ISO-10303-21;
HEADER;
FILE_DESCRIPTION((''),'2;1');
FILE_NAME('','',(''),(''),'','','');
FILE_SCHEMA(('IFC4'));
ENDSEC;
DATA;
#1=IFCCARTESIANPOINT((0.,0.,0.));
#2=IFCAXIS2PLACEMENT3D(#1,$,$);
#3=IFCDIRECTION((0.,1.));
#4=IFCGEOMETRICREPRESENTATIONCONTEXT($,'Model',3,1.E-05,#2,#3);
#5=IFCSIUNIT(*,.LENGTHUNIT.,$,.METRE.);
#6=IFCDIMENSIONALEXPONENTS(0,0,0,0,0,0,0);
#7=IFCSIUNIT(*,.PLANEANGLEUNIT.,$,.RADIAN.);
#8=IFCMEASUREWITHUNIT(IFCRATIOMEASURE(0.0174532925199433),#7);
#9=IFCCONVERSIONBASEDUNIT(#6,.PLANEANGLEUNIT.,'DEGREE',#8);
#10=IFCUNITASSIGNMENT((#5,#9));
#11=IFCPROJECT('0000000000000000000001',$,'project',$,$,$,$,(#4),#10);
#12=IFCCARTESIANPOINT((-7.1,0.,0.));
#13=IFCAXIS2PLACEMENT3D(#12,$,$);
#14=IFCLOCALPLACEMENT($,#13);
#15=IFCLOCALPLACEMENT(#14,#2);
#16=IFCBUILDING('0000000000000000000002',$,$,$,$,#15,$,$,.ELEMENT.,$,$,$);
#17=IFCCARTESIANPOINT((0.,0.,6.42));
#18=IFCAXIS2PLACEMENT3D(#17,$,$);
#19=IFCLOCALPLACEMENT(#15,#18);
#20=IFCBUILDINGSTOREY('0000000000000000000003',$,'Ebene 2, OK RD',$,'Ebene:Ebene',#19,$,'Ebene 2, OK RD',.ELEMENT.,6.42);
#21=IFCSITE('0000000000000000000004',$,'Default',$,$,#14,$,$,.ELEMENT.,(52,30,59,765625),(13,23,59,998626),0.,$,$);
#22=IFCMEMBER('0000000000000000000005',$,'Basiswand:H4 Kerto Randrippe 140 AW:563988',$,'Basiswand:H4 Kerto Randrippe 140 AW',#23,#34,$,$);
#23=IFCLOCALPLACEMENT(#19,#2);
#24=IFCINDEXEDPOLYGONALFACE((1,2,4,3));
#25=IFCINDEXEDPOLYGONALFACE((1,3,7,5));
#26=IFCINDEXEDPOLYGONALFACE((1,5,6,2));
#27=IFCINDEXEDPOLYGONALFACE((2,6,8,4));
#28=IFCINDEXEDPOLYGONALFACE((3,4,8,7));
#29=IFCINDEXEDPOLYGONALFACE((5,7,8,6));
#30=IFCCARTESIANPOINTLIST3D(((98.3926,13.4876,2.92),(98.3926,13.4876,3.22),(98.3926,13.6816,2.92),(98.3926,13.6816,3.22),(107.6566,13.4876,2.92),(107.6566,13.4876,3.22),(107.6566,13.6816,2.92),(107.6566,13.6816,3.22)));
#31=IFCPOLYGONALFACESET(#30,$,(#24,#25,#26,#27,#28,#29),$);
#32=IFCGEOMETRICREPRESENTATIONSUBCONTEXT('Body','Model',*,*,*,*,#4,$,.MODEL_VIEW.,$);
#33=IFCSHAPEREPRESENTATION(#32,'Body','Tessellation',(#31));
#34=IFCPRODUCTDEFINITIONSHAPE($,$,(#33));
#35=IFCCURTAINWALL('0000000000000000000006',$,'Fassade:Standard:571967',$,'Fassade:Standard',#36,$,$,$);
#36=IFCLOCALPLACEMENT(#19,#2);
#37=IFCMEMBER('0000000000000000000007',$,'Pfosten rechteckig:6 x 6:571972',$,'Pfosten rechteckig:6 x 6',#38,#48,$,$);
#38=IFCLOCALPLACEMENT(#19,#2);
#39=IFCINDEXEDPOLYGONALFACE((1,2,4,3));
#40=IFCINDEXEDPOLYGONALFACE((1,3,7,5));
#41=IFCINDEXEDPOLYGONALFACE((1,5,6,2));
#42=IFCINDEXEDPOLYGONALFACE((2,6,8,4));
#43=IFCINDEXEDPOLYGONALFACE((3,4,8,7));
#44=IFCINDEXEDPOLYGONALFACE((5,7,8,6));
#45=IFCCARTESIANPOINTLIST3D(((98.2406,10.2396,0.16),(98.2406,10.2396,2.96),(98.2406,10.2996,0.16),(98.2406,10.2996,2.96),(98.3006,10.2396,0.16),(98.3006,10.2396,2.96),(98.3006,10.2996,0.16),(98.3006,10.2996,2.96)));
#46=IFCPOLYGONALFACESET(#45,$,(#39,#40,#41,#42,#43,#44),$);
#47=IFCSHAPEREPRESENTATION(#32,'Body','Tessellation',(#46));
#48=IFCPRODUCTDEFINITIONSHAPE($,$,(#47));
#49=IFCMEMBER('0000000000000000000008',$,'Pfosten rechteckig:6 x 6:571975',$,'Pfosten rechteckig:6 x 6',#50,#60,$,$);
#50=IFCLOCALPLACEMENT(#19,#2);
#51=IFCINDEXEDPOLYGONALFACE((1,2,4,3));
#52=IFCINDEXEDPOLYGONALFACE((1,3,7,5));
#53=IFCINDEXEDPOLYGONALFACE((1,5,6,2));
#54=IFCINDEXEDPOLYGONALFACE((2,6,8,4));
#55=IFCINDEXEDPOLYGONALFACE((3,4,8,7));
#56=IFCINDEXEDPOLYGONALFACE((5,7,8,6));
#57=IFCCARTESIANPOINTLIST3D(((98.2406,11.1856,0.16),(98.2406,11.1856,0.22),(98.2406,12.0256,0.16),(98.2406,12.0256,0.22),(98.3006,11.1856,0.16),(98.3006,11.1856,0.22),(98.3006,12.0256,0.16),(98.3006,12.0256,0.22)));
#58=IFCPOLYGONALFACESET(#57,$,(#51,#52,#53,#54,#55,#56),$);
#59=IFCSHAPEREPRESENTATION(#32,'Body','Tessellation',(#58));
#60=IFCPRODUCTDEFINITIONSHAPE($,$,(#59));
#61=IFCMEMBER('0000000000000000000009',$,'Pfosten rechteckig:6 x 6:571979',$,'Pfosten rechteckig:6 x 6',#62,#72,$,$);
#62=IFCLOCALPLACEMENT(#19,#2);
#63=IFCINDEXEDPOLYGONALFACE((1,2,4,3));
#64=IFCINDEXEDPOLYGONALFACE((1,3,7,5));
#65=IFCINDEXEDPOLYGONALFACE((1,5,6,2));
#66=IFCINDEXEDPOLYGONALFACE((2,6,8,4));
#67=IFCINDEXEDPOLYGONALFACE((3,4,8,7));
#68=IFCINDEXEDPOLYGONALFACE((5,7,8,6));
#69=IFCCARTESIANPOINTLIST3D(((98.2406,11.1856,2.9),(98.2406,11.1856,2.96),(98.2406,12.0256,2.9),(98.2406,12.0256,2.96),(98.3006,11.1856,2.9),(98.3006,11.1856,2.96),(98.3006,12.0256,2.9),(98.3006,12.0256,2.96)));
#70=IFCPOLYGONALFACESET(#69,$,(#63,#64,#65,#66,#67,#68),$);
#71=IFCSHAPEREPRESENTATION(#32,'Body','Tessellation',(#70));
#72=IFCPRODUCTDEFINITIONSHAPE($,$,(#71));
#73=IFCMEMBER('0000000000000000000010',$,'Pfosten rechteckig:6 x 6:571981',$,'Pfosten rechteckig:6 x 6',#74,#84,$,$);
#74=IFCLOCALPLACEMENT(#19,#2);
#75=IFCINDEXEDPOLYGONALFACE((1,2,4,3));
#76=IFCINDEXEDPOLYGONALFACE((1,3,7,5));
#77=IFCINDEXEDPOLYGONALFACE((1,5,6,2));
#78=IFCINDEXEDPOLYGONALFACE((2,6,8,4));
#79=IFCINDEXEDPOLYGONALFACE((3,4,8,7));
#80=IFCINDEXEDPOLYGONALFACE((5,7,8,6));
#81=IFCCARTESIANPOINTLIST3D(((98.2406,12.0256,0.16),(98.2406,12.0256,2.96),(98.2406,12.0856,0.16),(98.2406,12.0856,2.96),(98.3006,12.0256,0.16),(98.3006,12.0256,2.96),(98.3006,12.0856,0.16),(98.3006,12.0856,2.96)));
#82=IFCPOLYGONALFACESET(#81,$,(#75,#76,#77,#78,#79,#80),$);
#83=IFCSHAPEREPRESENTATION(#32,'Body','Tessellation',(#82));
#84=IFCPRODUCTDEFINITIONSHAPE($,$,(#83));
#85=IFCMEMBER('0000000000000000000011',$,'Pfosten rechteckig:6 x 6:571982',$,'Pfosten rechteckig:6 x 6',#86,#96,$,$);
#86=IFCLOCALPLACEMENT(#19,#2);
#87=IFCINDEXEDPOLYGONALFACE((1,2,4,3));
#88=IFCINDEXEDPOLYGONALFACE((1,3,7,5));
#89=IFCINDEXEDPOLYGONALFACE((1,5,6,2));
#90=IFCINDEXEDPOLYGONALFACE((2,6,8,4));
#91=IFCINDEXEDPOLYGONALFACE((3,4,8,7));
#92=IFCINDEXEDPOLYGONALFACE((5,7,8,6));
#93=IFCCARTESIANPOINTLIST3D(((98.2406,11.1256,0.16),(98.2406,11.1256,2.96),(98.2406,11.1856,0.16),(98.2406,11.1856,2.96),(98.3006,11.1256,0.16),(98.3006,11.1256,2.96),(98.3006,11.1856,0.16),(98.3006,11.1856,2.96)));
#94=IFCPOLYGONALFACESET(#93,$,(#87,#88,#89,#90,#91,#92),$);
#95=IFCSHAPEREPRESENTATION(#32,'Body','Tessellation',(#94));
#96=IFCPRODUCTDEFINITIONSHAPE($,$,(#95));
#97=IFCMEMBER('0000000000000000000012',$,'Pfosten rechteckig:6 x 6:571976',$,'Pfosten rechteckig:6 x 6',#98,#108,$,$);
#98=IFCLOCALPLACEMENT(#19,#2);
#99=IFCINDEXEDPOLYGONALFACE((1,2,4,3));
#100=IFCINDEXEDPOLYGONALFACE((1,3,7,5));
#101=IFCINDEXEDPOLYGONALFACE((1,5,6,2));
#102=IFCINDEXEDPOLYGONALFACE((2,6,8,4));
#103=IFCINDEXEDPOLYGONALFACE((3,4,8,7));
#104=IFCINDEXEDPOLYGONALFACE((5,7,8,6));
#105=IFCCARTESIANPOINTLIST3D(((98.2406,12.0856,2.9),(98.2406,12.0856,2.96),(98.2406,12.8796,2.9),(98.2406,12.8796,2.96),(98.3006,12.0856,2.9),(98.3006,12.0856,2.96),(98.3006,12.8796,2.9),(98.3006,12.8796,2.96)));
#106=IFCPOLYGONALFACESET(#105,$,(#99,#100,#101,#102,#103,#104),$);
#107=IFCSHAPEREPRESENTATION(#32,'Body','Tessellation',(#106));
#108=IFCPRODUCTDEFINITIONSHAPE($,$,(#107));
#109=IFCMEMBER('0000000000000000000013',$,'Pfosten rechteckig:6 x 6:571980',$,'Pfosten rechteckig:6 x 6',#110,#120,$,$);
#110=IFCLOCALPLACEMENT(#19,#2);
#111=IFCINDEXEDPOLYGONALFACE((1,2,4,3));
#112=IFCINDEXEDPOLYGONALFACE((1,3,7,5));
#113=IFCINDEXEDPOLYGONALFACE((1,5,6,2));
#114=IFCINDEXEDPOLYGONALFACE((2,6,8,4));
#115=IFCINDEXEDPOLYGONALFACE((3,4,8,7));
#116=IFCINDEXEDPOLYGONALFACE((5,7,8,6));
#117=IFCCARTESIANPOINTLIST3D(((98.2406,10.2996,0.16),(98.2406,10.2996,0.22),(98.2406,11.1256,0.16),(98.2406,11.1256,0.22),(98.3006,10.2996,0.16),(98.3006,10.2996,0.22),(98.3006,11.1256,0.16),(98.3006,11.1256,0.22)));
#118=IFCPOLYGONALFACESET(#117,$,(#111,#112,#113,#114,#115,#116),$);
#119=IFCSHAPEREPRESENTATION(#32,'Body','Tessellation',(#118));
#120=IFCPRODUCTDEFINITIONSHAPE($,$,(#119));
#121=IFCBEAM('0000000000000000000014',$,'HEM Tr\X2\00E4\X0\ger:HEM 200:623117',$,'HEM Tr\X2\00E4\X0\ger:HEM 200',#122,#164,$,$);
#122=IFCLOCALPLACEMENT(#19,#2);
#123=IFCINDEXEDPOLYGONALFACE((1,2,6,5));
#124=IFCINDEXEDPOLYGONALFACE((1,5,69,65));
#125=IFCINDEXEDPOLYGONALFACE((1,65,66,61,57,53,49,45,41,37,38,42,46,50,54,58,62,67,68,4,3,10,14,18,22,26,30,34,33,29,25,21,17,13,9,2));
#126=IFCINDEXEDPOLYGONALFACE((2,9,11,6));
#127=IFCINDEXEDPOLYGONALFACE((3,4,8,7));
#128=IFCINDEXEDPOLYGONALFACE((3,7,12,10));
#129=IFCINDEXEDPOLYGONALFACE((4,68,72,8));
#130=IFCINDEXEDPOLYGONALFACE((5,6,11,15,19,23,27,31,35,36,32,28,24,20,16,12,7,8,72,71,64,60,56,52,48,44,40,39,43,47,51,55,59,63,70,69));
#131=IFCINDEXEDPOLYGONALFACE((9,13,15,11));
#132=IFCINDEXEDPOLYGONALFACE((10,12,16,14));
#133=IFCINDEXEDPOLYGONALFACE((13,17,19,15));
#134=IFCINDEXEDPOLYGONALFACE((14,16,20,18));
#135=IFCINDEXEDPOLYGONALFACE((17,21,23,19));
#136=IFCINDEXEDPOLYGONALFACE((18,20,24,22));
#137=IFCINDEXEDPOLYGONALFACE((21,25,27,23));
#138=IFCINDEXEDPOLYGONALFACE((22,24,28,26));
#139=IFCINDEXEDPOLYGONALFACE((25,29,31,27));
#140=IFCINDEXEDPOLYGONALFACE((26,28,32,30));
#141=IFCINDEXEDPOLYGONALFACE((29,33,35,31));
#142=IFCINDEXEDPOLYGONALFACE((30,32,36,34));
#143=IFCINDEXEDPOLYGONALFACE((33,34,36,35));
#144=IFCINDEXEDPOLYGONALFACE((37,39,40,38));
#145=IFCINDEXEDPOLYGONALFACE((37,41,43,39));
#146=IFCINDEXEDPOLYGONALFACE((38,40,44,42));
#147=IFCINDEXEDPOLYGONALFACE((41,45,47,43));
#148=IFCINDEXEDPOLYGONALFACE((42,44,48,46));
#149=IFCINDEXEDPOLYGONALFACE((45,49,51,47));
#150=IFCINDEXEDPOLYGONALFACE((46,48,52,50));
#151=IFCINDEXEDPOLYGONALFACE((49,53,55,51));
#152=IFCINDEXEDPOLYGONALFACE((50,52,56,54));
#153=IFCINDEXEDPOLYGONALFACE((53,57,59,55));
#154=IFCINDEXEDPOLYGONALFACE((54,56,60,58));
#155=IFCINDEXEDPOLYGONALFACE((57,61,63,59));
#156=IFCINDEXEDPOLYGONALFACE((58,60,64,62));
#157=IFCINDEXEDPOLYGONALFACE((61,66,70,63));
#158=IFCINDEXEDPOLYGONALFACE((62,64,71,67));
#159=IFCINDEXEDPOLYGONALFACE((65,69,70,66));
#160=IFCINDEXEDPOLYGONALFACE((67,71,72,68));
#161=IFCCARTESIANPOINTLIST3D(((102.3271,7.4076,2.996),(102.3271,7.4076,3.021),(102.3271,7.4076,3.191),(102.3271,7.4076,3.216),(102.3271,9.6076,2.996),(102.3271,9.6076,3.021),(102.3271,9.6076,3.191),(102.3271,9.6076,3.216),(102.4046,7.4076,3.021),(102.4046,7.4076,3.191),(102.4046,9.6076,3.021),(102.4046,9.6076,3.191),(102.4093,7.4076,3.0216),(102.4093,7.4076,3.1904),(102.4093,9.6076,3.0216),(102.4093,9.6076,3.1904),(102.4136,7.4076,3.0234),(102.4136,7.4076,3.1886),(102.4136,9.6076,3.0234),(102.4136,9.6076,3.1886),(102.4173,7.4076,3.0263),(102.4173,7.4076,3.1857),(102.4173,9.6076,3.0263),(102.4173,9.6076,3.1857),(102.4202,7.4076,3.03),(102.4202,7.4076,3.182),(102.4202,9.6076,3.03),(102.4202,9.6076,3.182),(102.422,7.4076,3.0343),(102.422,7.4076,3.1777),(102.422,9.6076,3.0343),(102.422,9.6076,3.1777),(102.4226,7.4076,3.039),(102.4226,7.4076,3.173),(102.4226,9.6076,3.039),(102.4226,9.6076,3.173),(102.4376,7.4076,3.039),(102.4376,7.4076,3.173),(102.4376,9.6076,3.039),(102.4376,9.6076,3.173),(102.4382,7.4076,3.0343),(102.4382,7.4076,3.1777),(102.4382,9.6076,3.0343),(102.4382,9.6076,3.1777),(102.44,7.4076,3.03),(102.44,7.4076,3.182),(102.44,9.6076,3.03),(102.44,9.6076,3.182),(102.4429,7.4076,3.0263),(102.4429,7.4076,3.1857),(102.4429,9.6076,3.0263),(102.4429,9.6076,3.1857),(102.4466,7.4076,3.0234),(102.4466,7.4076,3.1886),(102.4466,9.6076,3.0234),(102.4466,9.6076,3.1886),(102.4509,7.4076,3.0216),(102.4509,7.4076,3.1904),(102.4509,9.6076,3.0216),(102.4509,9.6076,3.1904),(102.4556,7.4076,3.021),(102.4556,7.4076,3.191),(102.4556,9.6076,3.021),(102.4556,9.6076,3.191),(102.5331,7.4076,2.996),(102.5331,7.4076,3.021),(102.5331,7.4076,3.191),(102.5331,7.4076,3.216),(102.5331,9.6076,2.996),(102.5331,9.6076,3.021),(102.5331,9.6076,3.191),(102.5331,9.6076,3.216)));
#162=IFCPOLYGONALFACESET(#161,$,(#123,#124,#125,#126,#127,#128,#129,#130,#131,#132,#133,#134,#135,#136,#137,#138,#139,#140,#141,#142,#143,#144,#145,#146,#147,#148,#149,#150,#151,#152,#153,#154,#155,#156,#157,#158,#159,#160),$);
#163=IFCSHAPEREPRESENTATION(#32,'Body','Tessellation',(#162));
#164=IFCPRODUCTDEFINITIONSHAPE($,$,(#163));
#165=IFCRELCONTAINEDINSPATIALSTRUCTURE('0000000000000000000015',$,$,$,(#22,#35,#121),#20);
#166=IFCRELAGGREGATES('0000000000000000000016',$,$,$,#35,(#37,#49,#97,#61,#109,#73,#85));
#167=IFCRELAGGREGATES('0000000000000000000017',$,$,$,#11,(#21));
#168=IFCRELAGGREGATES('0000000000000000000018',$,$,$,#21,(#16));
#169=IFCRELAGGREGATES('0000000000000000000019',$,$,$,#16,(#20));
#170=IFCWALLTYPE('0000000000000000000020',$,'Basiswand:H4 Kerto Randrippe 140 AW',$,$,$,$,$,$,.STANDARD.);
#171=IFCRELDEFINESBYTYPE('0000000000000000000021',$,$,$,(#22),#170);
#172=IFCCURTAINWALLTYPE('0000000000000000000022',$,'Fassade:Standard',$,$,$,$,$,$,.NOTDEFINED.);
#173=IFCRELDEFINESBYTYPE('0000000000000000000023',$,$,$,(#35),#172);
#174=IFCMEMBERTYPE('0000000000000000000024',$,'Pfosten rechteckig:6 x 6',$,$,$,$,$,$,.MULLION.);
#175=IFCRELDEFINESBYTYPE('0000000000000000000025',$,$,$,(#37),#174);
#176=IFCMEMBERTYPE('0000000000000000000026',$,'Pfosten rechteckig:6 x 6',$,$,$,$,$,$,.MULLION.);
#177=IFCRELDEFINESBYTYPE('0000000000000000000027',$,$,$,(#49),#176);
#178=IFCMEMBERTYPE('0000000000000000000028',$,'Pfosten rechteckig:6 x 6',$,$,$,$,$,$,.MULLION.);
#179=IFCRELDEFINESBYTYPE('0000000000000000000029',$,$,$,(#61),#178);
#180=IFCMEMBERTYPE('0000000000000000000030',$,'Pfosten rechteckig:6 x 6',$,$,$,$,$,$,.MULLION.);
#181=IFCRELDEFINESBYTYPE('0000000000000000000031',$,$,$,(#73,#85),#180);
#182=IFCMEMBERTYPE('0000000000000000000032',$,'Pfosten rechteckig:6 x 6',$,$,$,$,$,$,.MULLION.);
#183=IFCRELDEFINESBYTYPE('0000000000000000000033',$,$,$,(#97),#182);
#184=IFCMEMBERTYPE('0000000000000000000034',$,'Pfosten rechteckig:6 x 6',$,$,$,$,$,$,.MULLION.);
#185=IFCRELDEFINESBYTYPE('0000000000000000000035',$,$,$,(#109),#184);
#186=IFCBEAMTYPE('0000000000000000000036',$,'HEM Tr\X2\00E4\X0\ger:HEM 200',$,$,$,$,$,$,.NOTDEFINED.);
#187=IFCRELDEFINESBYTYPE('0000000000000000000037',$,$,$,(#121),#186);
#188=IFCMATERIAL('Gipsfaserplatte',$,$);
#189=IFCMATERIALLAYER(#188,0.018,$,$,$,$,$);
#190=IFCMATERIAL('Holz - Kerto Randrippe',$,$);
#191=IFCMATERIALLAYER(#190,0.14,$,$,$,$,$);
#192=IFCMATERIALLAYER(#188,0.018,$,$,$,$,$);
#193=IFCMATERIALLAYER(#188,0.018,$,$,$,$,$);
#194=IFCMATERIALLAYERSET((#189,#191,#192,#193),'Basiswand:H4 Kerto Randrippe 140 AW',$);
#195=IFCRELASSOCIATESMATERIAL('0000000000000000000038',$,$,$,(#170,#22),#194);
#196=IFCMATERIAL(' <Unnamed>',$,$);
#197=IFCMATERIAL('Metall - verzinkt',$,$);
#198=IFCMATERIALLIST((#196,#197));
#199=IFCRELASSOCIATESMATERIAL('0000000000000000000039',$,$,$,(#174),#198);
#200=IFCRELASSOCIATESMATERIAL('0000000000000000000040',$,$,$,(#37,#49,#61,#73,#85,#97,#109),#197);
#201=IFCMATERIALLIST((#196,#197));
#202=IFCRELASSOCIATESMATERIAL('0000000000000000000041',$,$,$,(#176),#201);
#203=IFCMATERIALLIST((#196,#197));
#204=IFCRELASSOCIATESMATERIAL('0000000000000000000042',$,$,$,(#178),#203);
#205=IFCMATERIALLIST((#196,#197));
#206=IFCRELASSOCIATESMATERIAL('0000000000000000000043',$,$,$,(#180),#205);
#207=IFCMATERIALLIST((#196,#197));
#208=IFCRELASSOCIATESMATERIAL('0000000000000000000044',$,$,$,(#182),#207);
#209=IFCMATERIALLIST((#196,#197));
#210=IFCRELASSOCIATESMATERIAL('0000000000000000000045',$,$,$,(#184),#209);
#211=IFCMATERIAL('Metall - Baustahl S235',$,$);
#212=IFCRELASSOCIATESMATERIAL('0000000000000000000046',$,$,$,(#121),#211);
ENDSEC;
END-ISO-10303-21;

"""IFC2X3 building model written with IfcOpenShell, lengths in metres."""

from ifc_helpers import new_model, entity, si_unit, converted_unit, direction, frame, frame_2d, origin, origin_2d_with_axis, place, context, subcontext, project, spatial, rectangle, i_section, extrude, source, transform, mapped, material, material_list, layer, layer_set, layer_usage, type_object, type_shapes, element, aggregate, save


model = new_model("IFC2X3")

# Units and contexts
model_context = context("Model", 3, precision=1e-05, world=origin(), true_north=direction((0.0, 1.0)))
body_context = subcontext(model_context, "Body", "Model", "MODEL_VIEW")
ifc_project = project(units=[si_unit("LENGTHUNIT", "METRE"), converted_unit("PLANEANGLEUNIT", "DEGREE", entity("IfcRatioMeasure", 0.0174532925199433), si_unit("PLANEANGLEUNIT", "RADIAN"), dimensions=[0, 0, 0, 0, 0, 0, 0])], contexts=[model_context])

# Site, building, storey
site_placement = place(None, frame((-7.1, 0.0, 0.0)))
site = spatial("IfcSite", under=ifc_project, at=site_placement, Name="Default", CompositionType="ELEMENT", RefLatitude=(52, 30, 59, 765625), RefLongitude=(13, 23, 59, 998626), RefElevation=0.0)
building_placement = place(site_placement, origin())
building = spatial("IfcBuilding", under=site, at=building_placement, CompositionType="ELEMENT")
storey_placement = place(building_placement, frame((0.0, 0.0, 6.42)))
storey = spatial("IfcBuildingStorey", under=building, at=storey_placement, Name="Ebene 2, OK RD", ObjectType="Ebene:Ebene", LongName="Ebene 2, OK RD", CompositionType="ELEMENT", Elevation=6.42)

# Member
ifc_material_1 = material(Name="Gipsfaserplatte")
ifc_layer_1 = layer(ifc_material_1, 0.018)
ifc_material_2 = material(Name="Holz - Kerto Randrippe")
ifc_layer_2 = layer(ifc_material_2, 0.14)
ifc_layer_3 = layer(ifc_material_1, 0.018)
ifc_layer_4 = layer(ifc_material_1, 0.018)
ifc_layer_set_1 = layer_set([ifc_layer_1, ifc_layer_2, ifc_layer_3, ifc_layer_4], Name="Basiswand:H4 Kerto Randrippe 140 AW")
ifc_layer_usage_1 = layer_usage(ifc_layer_set_1, "AXIS2", "NEGATIVE", 0.097)
wall_type_1 = type_object("IfcWallType", Name="Basiswand:H4 Kerto Randrippe 140 AW", PredefinedType="STANDARD", material=ifc_layer_set_1)
member_1_placement = place(storey_placement, frame((98.3926, 13.5846, 2.92)))
element("IfcMember", 1, at=member_1_placement, inside=storey, type_object=wall_type_1, material=ifc_layer_usage_1, Name="Basiswand:H4 Kerto Randrippe 140 AW:563988", ObjectType="Basiswand:H4 Kerto Randrippe 140 AW", context=body_context, shape_type="SweptSolid", body=[
    extrude(rectangle(XDim=9.264, YDim=0.194, at=frame_2d((4.632, 0.0), x_axis=(-1.0, 0.0))), origin(), (0.0, 0.0, 1.0), 0.3),
])

# Curtain wall, members
curtain_wall_type = type_object("IfcCurtainWallType", Name="Fassade:Standard", PredefinedType="NOTDEFINED")
curtain_wall_placement = place(storey_placement, frame((0.0, 0.0, -6.42)))
curtain_wall = element("IfcCurtainWall", 2, at=curtain_wall_placement, inside=storey, type_object=curtain_wall_type, Name="Fassade:Standard:571967", ObjectType="Fassade:Standard")
ifc_material_3 = material(Name="Metall - verzinkt")
ifc_material_4 = material(Name=" <Unnamed>")
ifc_material_list_1 = material_list([ifc_material_4, ifc_material_3])
member_type_1 = type_object("IfcMemberType", Name="Pfosten rechteckig:6 x 6", PredefinedType="MULLION", material=ifc_material_list_1)
shared_shape_1 = source(origin(), body_context, "Body", "SweptSolid", [
    extrude(rectangle(XDim=0.06, YDim=0.06, at=origin_2d_with_axis()), frame((-0.03, 0.0, -2.8), z_axis=(0.0, 0.0, 1.0), x_axis=(0.0, -1.0, 0.0)), (0.0, 0.0, 1.0), 2.8),
])
type_shapes(member_type_1, [shared_shape_1])
member_2_placement = place(storey_placement, frame((98.2706, 10.2396, 0.16), z_axis=(0.0, 0.0, -1.0), x_axis=(0.0, -1.0, 0.0)))
member_2 = element("IfcMember", 3, at=member_2_placement, type_object=member_type_1, material=ifc_material_3, Name="Pfosten rechteckig:6 x 6:571972", ObjectType="Pfosten rechteckig:6 x 6", context=body_context, shape_type="MappedRepresentation", body=[
    mapped(shared_shape_1, transform((0.0, 0.0, 0.0), scale=1.0)),
])
ifc_material_list_2 = material_list([ifc_material_4, ifc_material_3])
member_type_2 = type_object("IfcMemberType", Name="Pfosten rechteckig:6 x 6", PredefinedType="MULLION", material=ifc_material_list_2)
shared_shape_2 = source(origin(), body_context, "Body", "SweptSolid", [
    extrude(rectangle(XDim=0.06, YDim=0.06, at=origin_2d_with_axis()), frame((-0.03, 0.0, -0.84), z_axis=(0.0, 0.0, 1.0), x_axis=(0.0, -1.0, 0.0)), (0.0, 0.0, 1.0), 0.84),
])
type_shapes(member_type_2, [shared_shape_2])
member_3_placement = place(storey_placement, frame((98.2706, 12.0256, 0.16), z_axis=(0.0, 1.0, 0.0), x_axis=(0.0, 0.0, -1.0)))
member_3 = element("IfcMember", 4, at=member_3_placement, type_object=member_type_2, material=ifc_material_3, Name="Pfosten rechteckig:6 x 6:571975", ObjectType="Pfosten rechteckig:6 x 6", context=body_context, shape_type="MappedRepresentation", body=[
    mapped(shared_shape_2, transform((0.0, 0.0, 0.0), scale=1.0)),
])
ifc_material_list_3 = material_list([ifc_material_4, ifc_material_3])
member_type_3 = type_object("IfcMemberType", Name="Pfosten rechteckig:6 x 6", PredefinedType="MULLION", material=ifc_material_list_3)
shared_shape_3 = source(origin(), body_context, "Body", "SweptSolid", [
    extrude(rectangle(XDim=0.06, YDim=0.06, at=origin_2d_with_axis()), frame((-0.03, 0.0, -0.84), z_axis=(0.0, 0.0, 1.0), x_axis=(0.0, -1.0, 0.0)), (0.0, 0.0, 1.0), 0.84),
])
type_shapes(member_type_3, [shared_shape_3])
member_4_placement = place(storey_placement, frame((98.2706, 11.1856, 2.96), z_axis=(0.0, -1.0, 0.0), x_axis=(0.0, 0.0, 1.0)))
member_4 = element("IfcMember", 5, at=member_4_placement, type_object=member_type_3, material=ifc_material_3, Name="Pfosten rechteckig:6 x 6:571979", ObjectType="Pfosten rechteckig:6 x 6", context=body_context, shape_type="MappedRepresentation", body=[
    mapped(shared_shape_3, transform((0.0, 0.0, 0.0), scale=1.0)),
])
ifc_material_list_4 = material_list([ifc_material_4, ifc_material_3])
member_type_4 = type_object("IfcMemberType", Name="Pfosten rechteckig:6 x 6", PredefinedType="MULLION", material=ifc_material_list_4)
shared_shape_4 = source(origin(), body_context, "Body", "SweptSolid", [
    extrude(rectangle(XDim=0.06, YDim=0.06, at=origin_2d_with_axis()), frame((0.0, 0.0, -2.8), z_axis=(0.0, 0.0, 1.0), x_axis=(0.0, -1.0, 0.0)), (0.0, 0.0, 1.0), 2.8),
])
type_shapes(member_type_4, [shared_shape_4])
member_5_placement = place(storey_placement, frame((98.2706, 12.0556, 0.16), z_axis=(0.0, 0.0, -1.0), x_axis=(0.0, -1.0, 0.0)))
member_5 = element("IfcMember", 6, at=member_5_placement, type_object=member_type_4, material=ifc_material_3, Name="Pfosten rechteckig:6 x 6:571981", ObjectType="Pfosten rechteckig:6 x 6", context=body_context, shape_type="MappedRepresentation", body=[
    mapped(shared_shape_4, transform((0.0, 0.0, 0.0), scale=1.0)),
])
member_6_placement = place(storey_placement, frame((98.2706, 11.1556, 0.16), z_axis=(0.0, 0.0, -1.0), x_axis=(0.0, -1.0, 0.0)))
member_6 = element("IfcMember", 7, at=member_6_placement, type_object=member_type_4, material=ifc_material_3, Name="Pfosten rechteckig:6 x 6:571982", ObjectType="Pfosten rechteckig:6 x 6", context=body_context, shape_type="MappedRepresentation", body=[
    mapped(shared_shape_4, transform((0.0, 0.0, 0.0), scale=1.0)),
])
ifc_material_list_5 = material_list([ifc_material_4, ifc_material_3])
member_type_5 = type_object("IfcMemberType", Name="Pfosten rechteckig:6 x 6", PredefinedType="MULLION", material=ifc_material_list_5)
shared_shape_5 = source(origin(), body_context, "Body", "SweptSolid", [
    extrude(rectangle(XDim=0.06, YDim=0.06, at=origin_2d_with_axis()), frame((-0.03, 0.0, -0.794), z_axis=(0.0, 0.0, 1.0), x_axis=(0.0, -1.0, 0.0)), (0.0, 0.0, 1.0), 0.794),
])
type_shapes(member_type_5, [shared_shape_5])
member_7_placement = place(storey_placement, frame((98.2706, 12.0856, 2.96), z_axis=(0.0, -1.0, 0.0), x_axis=(0.0, 0.0, 1.0)))
member_7 = element("IfcMember", 8, at=member_7_placement, type_object=member_type_5, material=ifc_material_3, Name="Pfosten rechteckig:6 x 6:571976", ObjectType="Pfosten rechteckig:6 x 6", context=body_context, shape_type="MappedRepresentation", body=[
    mapped(shared_shape_5, transform((0.0, 0.0, 0.0), scale=1.0)),
])
ifc_material_list_6 = material_list([ifc_material_4, ifc_material_3])
member_type_6 = type_object("IfcMemberType", Name="Pfosten rechteckig:6 x 6", PredefinedType="MULLION", material=ifc_material_list_6)
shared_shape_6 = source(origin(), body_context, "Body", "SweptSolid", [
    extrude(rectangle(XDim=0.06, YDim=0.06, at=origin_2d_with_axis()), frame((-0.03, 0.0, -0.826), z_axis=(0.0, 0.0, 1.0), x_axis=(0.0, -1.0, 0.0)), (0.0, 0.0, 1.0), 0.826),
])
type_shapes(member_type_6, [shared_shape_6])
member_8_placement = place(storey_placement, frame((98.2706, 11.1256, 0.16), z_axis=(0.0, 1.0, 0.0), x_axis=(0.0, 0.0, -1.0)))
member_8 = element("IfcMember", 9, at=member_8_placement, type_object=member_type_6, material=ifc_material_3, Name="Pfosten rechteckig:6 x 6:571980", ObjectType="Pfosten rechteckig:6 x 6", context=body_context, shape_type="MappedRepresentation", body=[
    mapped(shared_shape_6, transform((0.0, 0.0, 0.0), scale=1.0)),
])
aggregate(curtain_wall, [member_2, member_3, member_7, member_4, member_8, member_5, member_6])

# Beam
ifc_material_5 = material(Name="Metall - Baustahl S235")
beam_type = type_object("IfcBeamType", Name="HEM Träger:HEM 200", PredefinedType="NOTDEFINED")
beam_placement = place(storey_placement, frame((102.4301, 7.4076, 2.996), z_axis=(0.0, 0.0, 1.0), x_axis=(0.0, 1.0, 0.0)))
element("IfcBeam", 10, at=beam_placement, inside=storey, type_object=beam_type, material=ifc_material_5, Name="HEM Träger:HEM 200:623117", ObjectType="HEM Träger:HEM 200", context=body_context, shape_type="SweptSolid", body=[
    extrude(i_section(OverallWidth=0.206, OverallDepth=0.22, WebThickness=0.015, FlangeThickness=0.025, FilletRadius=0.018, at=frame_2d((0.0, 0.0), x_axis=(0.0, 1.0))), frame((0.0, 0.0, 0.11), z_axis=(1.0, 0.0, 0.0), x_axis=(0.0, 0.0, -1.0)), (0.0, 0.0, 1.0), 2.2),
])

save(model, "model.ifc")
